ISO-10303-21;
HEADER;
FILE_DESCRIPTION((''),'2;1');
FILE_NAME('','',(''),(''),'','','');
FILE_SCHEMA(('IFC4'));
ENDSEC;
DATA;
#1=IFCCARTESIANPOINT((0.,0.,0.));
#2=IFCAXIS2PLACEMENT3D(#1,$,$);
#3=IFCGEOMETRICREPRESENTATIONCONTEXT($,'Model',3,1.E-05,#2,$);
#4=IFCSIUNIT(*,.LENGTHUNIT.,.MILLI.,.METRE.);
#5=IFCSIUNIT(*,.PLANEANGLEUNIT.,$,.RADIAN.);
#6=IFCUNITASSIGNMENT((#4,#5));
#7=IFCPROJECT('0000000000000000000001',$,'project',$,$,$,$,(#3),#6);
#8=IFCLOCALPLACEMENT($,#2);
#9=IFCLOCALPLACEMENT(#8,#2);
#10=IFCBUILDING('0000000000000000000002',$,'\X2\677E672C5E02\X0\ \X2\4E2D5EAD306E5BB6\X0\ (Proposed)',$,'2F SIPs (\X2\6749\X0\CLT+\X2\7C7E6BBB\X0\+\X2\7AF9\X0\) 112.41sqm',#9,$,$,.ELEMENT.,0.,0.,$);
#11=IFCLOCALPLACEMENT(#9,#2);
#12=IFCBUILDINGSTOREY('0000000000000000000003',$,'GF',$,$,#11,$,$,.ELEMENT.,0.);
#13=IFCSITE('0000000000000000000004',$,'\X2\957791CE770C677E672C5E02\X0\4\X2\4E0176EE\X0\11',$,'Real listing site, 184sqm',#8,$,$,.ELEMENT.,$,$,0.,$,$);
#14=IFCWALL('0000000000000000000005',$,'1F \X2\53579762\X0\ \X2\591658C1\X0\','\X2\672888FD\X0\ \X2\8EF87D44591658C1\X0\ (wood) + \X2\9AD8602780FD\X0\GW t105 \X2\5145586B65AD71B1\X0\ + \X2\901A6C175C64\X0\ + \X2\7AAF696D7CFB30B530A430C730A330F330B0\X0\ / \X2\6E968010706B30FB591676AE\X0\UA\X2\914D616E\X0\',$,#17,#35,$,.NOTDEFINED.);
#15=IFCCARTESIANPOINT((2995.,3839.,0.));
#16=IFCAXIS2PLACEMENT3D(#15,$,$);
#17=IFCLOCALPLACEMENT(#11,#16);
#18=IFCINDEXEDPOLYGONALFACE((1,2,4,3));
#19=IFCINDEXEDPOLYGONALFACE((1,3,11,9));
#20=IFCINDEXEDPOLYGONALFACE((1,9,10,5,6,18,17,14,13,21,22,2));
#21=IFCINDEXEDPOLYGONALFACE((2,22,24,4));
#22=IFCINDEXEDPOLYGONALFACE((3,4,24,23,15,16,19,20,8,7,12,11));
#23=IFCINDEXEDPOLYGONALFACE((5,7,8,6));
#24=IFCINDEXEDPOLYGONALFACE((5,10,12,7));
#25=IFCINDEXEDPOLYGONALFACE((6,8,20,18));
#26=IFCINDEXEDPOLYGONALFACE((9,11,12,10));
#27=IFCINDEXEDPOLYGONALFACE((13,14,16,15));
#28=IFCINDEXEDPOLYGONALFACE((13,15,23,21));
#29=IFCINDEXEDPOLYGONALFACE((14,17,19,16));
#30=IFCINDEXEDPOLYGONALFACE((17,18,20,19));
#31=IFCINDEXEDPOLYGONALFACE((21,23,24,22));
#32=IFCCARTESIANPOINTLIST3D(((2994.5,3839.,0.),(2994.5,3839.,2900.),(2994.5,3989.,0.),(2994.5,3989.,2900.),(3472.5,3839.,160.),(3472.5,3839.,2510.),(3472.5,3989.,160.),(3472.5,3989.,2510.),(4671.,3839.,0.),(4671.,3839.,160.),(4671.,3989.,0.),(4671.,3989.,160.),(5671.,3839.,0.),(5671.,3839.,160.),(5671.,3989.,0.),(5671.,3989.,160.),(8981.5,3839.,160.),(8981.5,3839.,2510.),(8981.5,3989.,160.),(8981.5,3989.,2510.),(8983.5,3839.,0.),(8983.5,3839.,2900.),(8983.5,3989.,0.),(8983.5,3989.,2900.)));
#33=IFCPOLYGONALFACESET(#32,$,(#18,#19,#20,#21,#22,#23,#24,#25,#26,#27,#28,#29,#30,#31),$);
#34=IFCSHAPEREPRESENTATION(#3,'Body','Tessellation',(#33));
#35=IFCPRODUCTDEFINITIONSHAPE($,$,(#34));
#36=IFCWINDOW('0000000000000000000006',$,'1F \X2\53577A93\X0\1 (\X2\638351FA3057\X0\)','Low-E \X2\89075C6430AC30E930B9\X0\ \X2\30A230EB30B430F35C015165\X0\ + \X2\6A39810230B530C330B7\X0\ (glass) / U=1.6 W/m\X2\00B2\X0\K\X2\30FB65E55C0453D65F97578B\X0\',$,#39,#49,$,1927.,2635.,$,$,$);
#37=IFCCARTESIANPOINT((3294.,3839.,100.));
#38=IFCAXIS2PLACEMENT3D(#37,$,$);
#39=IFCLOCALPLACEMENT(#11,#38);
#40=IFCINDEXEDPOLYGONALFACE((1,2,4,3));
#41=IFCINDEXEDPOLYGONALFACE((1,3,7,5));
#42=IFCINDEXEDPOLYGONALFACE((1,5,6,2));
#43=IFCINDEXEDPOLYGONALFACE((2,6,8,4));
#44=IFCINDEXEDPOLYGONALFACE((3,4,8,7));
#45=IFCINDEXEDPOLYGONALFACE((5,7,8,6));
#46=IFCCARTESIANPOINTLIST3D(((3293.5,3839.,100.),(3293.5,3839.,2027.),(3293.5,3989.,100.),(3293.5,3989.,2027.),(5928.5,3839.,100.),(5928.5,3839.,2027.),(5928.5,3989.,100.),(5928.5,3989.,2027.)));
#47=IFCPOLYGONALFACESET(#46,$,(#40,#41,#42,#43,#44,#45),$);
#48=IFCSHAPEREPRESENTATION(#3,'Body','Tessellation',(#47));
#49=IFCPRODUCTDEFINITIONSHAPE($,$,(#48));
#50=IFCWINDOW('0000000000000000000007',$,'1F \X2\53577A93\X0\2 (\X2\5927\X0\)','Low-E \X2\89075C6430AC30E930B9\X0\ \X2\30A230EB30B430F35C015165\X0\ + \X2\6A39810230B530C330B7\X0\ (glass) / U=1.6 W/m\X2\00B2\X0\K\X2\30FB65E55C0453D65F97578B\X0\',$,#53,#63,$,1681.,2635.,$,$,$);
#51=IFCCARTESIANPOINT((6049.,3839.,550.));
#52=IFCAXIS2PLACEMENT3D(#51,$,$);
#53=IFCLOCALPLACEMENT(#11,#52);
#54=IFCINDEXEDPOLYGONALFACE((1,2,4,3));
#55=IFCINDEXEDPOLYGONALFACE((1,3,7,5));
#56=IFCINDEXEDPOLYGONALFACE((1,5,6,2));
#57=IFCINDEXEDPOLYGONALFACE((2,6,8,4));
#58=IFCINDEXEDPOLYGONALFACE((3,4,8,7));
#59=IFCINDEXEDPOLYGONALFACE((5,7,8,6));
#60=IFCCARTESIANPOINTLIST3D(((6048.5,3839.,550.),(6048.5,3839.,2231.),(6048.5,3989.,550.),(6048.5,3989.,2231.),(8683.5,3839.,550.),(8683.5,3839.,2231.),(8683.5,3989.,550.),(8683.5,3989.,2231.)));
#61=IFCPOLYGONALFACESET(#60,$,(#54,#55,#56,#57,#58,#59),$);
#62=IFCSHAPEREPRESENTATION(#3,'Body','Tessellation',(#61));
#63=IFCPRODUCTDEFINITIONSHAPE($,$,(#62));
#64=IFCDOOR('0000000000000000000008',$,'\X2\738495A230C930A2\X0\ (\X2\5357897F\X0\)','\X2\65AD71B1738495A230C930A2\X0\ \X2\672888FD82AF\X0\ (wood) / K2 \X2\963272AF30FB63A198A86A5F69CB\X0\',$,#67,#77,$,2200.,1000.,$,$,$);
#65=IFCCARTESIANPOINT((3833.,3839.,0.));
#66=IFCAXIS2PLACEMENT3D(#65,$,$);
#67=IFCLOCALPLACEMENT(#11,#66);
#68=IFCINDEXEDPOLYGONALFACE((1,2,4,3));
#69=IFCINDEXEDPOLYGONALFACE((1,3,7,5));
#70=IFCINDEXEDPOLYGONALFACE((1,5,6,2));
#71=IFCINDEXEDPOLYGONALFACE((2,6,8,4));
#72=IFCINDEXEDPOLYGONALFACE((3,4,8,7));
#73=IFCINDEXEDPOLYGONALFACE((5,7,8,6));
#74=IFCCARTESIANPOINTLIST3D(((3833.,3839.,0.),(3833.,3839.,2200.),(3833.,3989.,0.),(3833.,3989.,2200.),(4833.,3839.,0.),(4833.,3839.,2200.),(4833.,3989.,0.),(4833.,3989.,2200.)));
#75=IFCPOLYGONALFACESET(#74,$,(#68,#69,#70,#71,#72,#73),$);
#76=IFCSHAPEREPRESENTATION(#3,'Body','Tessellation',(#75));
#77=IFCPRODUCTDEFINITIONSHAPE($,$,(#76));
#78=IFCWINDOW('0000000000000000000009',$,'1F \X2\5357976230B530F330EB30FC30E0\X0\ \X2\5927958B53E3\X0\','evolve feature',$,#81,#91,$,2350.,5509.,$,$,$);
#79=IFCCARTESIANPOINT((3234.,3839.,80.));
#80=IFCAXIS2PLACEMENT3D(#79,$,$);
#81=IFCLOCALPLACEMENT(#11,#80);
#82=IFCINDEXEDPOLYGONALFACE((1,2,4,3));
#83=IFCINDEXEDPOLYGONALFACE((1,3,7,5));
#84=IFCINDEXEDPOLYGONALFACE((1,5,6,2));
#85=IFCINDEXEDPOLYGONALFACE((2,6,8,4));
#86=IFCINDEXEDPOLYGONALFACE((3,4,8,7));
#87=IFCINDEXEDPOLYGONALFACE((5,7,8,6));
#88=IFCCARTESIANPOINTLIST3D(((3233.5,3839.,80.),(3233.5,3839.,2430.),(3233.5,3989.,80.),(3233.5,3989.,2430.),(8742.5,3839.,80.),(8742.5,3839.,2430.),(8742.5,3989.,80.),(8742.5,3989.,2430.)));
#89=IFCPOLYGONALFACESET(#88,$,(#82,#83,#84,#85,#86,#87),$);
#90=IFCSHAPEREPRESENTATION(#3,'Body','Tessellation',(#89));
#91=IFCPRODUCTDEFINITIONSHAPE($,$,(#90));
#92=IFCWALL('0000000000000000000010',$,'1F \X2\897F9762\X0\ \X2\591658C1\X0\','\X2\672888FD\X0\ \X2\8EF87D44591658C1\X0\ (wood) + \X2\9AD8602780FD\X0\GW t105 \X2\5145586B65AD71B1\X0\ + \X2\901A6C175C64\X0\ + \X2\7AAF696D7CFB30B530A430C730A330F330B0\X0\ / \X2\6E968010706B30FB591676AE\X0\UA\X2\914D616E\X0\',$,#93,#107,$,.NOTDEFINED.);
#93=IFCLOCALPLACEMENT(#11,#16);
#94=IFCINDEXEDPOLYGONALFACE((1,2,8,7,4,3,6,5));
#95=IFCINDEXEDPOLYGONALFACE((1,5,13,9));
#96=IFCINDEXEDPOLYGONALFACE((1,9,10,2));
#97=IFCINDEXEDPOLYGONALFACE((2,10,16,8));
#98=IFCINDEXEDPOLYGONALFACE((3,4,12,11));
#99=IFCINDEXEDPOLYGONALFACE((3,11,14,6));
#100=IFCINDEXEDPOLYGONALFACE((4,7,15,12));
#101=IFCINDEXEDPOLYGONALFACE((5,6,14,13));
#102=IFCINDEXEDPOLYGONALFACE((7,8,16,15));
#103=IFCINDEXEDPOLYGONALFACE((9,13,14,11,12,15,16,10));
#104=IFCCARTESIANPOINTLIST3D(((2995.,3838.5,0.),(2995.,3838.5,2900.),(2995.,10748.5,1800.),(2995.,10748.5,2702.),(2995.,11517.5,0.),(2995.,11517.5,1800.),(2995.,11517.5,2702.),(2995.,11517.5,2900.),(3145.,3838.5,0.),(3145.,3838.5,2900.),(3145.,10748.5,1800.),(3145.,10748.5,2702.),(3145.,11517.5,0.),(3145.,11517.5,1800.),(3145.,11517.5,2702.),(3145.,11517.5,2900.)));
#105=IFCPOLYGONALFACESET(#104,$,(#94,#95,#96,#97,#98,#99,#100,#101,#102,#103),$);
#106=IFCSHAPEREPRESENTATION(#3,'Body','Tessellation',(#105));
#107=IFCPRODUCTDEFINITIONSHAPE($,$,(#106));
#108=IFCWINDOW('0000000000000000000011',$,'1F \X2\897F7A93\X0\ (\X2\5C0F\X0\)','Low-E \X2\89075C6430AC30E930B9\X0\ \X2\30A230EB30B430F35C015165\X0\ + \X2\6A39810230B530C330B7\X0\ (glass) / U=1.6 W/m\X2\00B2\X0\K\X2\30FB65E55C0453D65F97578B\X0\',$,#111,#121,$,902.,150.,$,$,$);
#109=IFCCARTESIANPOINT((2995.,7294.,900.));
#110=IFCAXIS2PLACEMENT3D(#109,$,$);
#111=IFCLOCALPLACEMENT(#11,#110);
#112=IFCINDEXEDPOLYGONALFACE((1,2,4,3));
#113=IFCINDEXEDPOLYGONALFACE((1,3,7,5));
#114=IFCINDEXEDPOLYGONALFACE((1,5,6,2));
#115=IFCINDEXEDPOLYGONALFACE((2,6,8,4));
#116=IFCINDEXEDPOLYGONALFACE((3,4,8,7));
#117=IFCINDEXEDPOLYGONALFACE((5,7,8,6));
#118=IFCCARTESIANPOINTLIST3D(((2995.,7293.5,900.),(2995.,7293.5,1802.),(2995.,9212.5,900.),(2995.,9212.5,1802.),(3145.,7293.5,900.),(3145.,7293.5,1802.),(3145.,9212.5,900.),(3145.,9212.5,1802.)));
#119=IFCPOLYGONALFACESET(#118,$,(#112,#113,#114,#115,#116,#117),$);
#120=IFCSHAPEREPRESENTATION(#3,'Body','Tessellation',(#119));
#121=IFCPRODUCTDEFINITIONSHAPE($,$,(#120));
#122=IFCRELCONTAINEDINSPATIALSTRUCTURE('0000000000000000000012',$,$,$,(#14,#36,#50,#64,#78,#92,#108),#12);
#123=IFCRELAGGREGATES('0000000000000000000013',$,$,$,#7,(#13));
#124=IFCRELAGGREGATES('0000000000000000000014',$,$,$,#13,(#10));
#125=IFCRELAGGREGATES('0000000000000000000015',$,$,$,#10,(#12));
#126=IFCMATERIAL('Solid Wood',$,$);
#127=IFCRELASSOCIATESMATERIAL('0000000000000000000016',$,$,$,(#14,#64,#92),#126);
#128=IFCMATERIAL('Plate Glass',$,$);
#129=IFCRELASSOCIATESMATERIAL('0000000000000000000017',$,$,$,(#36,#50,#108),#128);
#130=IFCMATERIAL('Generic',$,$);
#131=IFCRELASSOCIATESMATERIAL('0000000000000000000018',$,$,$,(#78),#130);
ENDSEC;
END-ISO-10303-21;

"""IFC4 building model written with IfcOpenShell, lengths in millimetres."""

from ifc_helpers import new_model, si_unit, frame, frame_2d, origin, place, context, project, spatial, rectangle, extrude, material, element, fill, save


model = new_model("IFC4")

# Units and contexts
model_context = context("Model", 3, precision=1e-05, world=origin())
ifc_project = project(units=[si_unit("LENGTHUNIT", "METRE", prefix="MILLI"), si_unit("PLANEANGLEUNIT", "RADIAN")], contexts=[model_context])

# Site, building, storey
site_placement = place(None, origin())
site = spatial("IfcSite", under=ifc_project, at=site_placement, Name="長野県松本市4丁目11", ObjectType="Real listing site, 184sqm", CompositionType="ELEMENT", RefElevation=0.0)
building_placement = place(site_placement, origin())
building = spatial("IfcBuilding", under=site, at=building_placement, Name="松本市 中庭の家 (Proposed)", ObjectType="2F SIPs (杉CLT+籾殻+竹) 112.41sqm", CompositionType="ELEMENT", ElevationOfRefHeight=0.0, ElevationOfTerrain=0.0)
storey_placement = place(building_placement, origin())
storey = spatial("IfcBuildingStorey", under=building, at=storey_placement, Name="GF", CompositionType="ELEMENT", Elevation=0.0)

# Shared definitions
ifc_material_1 = material(Name="Solid Wood")

# Wall, openings, windows, door
wall_1_placement = place(storey_placement, frame((2995.0, 3839.0, 0.0)))
wall_1 = element("IfcWall", 1, at=wall_1_placement, inside=storey, material=ifc_material_1, Name="1F 南面 外壁", Description="木製 軸組外壁 (wood) + 高性能GW t105 充填断熱 + 通気層 + 窯業系サイディング / 準耐火・外皮UA配慮", PredefinedType="NOTDEFINED", context=model_context, shape_type="SweptSolid", body=[
    extrude(rectangle(XDim=5989.0, YDim=150.0, at=frame_2d((2994.0, 75.0))), frame((2995.0, 3839.0, 0.0)), (0.0, 0.0, 1.0), 2900.0),
])
opening_1_placement = place(storey_placement, frame((3294.0, 3839.0, 100.0)))
opening_1 = element("IfcOpeningElement", 2, at=opening_1_placement, cuts=wall_1, PredefinedType="NOTDEFINED", context=model_context, shape_type="SweptSolid", body=[
    extrude(rectangle(XDim=2635.0, YDim=150.0, at=frame_2d((1317.0, 75.0))), frame((3294.0, 3839.0, 100.0)), (0.0, 0.0, 1.0), 1927.0),
])
opening_2_placement = place(storey_placement, frame((6049.0, 3839.0, 550.0)))
opening_2 = element("IfcOpeningElement", 3, at=opening_2_placement, cuts=wall_1, PredefinedType="NOTDEFINED", context=model_context, shape_type="SweptSolid", body=[
    extrude(rectangle(XDim=2635.0, YDim=150.0, at=frame_2d((1317.0, 75.0))), frame((6049.0, 3839.0, 550.0)), (0.0, 0.0, 1.0), 1681.0),
])
opening_3_placement = place(storey_placement, frame((3833.0, 3839.0, 0.0)))
opening_3 = element("IfcOpeningElement", 4, at=opening_3_placement, cuts=wall_1, PredefinedType="NOTDEFINED", context=model_context, shape_type="SweptSolid", body=[
    extrude(rectangle(XDim=1000.0, YDim=150.0, at=frame_2d((500.0, 75.0))), frame((3833.0, 3839.0, 0.0)), (0.0, 0.0, 1.0), 2200.0),
])
opening_4_placement = place(storey_placement, frame((3234.0, 3839.0, 80.0)))
opening_4 = element("IfcOpeningElement", 5, at=opening_4_placement, cuts=wall_1, PredefinedType="NOTDEFINED", context=model_context, shape_type="SweptSolid", body=[
    extrude(rectangle(XDim=5509.0, YDim=150.0, at=frame_2d((2754.0, 75.0))), frame((3234.0, 3839.0, 80.0)), (0.0, 0.0, 1.0), 2350.0),
])
ifc_material_2 = material(Name="Plate Glass")
window_1_placement = place(storey_placement, frame((3294.0, 3839.0, 100.0)))
window_1 = element("IfcWindow", 6, at=window_1_placement, inside=storey, material=ifc_material_2, Name="1F 南窓1 (掃出し)", Description="Low-E 複層ガラス アルゴン封入 + 樹脂サッシ (glass) / U=1.6 W/m²K・日射取得型", OverallHeight=1927.0, OverallWidth=2635.0, context=model_context, shape_type="SweptSolid", body=[
    extrude(rectangle(XDim=2635.0, YDim=150.0, at=frame_2d((1317.0, 75.0))), frame((3294.0, 3839.0, 100.0)), (0.0, 0.0, 1.0), 1927.0),
])
fill(opening_1, window_1)
window_2_placement = place(storey_placement, frame((6049.0, 3839.0, 550.0)))
window_2 = element("IfcWindow", 7, at=window_2_placement, inside=storey, material=ifc_material_2, Name="1F 南窓2 (大)", Description="Low-E 複層ガラス アルゴン封入 + 樹脂サッシ (glass) / U=1.6 W/m²K・日射取得型", OverallHeight=1681.0, OverallWidth=2635.0, context=model_context, shape_type="SweptSolid", body=[
    extrude(rectangle(XDim=2635.0, YDim=150.0, at=frame_2d((1317.0, 75.0))), frame((6049.0, 3839.0, 550.0)), (0.0, 0.0, 1.0), 1681.0),
])
fill(opening_2, window_2)
door_placement = place(storey_placement, frame((3833.0, 3839.0, 0.0)))
door = element("IfcDoor", 8, at=door_placement, inside=storey, material=ifc_material_1, Name="玄関ドア (南西)", Description="断熱玄関ドア 木製芯 (wood) / K2 防犯・採風機構", OverallHeight=2200.0, OverallWidth=1000.0, context=model_context, shape_type="SweptSolid", body=[
    extrude(rectangle(XDim=1000.0, YDim=150.0, at=frame_2d((500.0, 75.0))), frame((3833.0, 3839.0, 0.0)), (0.0, 0.0, 1.0), 2200.0),
])
fill(opening_3, door)
ifc_material_3 = material(Name="Generic")
window_3_placement = place(storey_placement, frame((3234.0, 3839.0, 80.0)))
window_3 = element("IfcWindow", 9, at=window_3_placement, inside=storey, material=ifc_material_3, Name="1F 南面サンルーム 大開口", Description="evolve feature", OverallHeight=2350.0, OverallWidth=5509.0, context=model_context, shape_type="SweptSolid", body=[
    extrude(rectangle(XDim=5509.0, YDim=150.0, at=frame_2d((2754.0, 75.0))), frame((3234.0, 3839.0, 80.0)), (0.0, 0.0, 1.0), 2350.0),
])
fill(opening_4, window_3)

# Wall, opening, window
wall_2_placement = place(storey_placement, frame((2995.0, 3839.0, 0.0)))
wall_2 = element("IfcWall", 10, at=wall_2_placement, inside=storey, material=ifc_material_1, Name="1F 西面 外壁", Description="木製 軸組外壁 (wood) + 高性能GW t105 充填断熱 + 通気層 + 窯業系サイディング / 準耐火・外皮UA配慮", PredefinedType="NOTDEFINED", context=model_context, shape_type="SweptSolid", body=[
    extrude(rectangle(XDim=150.0, YDim=7679.0, at=frame_2d((75.0, 3839.0))), frame((2995.0, 3839.0, 0.0)), (0.0, 0.0, 1.0), 2900.0),
])
opening_5_placement = place(storey_placement, frame((2995.0, 7294.0, 900.0)))
opening_5 = element("IfcOpeningElement", 11, at=opening_5_placement, cuts=wall_2, PredefinedType="NOTDEFINED", context=model_context, shape_type="SweptSolid", body=[
    extrude(rectangle(XDim=150.0, YDim=1919.0, at=frame_2d((75.0, 959.0))), frame((2995.0, 7294.0, 900.0)), (0.0, 0.0, 1.0), 902.0),
])
window_4_placement = place(storey_placement, frame((2995.0, 7294.0, 900.0)))
window_4 = element("IfcWindow", 12, at=window_4_placement, inside=storey, material=ifc_material_2, Name="1F 西窓 (小)", Description="Low-E 複層ガラス アルゴン封入 + 樹脂サッシ (glass) / U=1.6 W/m²K・日射取得型", OverallHeight=902.0, OverallWidth=150.0, context=model_context, shape_type="SweptSolid", body=[
    extrude(rectangle(XDim=150.0, YDim=1919.0, at=frame_2d((75.0, 959.0))), frame((2995.0, 7294.0, 900.0)), (0.0, 0.0, 1.0), 902.0),
])
fill(opening_5, window_4)

save(model, "model.ifc")
